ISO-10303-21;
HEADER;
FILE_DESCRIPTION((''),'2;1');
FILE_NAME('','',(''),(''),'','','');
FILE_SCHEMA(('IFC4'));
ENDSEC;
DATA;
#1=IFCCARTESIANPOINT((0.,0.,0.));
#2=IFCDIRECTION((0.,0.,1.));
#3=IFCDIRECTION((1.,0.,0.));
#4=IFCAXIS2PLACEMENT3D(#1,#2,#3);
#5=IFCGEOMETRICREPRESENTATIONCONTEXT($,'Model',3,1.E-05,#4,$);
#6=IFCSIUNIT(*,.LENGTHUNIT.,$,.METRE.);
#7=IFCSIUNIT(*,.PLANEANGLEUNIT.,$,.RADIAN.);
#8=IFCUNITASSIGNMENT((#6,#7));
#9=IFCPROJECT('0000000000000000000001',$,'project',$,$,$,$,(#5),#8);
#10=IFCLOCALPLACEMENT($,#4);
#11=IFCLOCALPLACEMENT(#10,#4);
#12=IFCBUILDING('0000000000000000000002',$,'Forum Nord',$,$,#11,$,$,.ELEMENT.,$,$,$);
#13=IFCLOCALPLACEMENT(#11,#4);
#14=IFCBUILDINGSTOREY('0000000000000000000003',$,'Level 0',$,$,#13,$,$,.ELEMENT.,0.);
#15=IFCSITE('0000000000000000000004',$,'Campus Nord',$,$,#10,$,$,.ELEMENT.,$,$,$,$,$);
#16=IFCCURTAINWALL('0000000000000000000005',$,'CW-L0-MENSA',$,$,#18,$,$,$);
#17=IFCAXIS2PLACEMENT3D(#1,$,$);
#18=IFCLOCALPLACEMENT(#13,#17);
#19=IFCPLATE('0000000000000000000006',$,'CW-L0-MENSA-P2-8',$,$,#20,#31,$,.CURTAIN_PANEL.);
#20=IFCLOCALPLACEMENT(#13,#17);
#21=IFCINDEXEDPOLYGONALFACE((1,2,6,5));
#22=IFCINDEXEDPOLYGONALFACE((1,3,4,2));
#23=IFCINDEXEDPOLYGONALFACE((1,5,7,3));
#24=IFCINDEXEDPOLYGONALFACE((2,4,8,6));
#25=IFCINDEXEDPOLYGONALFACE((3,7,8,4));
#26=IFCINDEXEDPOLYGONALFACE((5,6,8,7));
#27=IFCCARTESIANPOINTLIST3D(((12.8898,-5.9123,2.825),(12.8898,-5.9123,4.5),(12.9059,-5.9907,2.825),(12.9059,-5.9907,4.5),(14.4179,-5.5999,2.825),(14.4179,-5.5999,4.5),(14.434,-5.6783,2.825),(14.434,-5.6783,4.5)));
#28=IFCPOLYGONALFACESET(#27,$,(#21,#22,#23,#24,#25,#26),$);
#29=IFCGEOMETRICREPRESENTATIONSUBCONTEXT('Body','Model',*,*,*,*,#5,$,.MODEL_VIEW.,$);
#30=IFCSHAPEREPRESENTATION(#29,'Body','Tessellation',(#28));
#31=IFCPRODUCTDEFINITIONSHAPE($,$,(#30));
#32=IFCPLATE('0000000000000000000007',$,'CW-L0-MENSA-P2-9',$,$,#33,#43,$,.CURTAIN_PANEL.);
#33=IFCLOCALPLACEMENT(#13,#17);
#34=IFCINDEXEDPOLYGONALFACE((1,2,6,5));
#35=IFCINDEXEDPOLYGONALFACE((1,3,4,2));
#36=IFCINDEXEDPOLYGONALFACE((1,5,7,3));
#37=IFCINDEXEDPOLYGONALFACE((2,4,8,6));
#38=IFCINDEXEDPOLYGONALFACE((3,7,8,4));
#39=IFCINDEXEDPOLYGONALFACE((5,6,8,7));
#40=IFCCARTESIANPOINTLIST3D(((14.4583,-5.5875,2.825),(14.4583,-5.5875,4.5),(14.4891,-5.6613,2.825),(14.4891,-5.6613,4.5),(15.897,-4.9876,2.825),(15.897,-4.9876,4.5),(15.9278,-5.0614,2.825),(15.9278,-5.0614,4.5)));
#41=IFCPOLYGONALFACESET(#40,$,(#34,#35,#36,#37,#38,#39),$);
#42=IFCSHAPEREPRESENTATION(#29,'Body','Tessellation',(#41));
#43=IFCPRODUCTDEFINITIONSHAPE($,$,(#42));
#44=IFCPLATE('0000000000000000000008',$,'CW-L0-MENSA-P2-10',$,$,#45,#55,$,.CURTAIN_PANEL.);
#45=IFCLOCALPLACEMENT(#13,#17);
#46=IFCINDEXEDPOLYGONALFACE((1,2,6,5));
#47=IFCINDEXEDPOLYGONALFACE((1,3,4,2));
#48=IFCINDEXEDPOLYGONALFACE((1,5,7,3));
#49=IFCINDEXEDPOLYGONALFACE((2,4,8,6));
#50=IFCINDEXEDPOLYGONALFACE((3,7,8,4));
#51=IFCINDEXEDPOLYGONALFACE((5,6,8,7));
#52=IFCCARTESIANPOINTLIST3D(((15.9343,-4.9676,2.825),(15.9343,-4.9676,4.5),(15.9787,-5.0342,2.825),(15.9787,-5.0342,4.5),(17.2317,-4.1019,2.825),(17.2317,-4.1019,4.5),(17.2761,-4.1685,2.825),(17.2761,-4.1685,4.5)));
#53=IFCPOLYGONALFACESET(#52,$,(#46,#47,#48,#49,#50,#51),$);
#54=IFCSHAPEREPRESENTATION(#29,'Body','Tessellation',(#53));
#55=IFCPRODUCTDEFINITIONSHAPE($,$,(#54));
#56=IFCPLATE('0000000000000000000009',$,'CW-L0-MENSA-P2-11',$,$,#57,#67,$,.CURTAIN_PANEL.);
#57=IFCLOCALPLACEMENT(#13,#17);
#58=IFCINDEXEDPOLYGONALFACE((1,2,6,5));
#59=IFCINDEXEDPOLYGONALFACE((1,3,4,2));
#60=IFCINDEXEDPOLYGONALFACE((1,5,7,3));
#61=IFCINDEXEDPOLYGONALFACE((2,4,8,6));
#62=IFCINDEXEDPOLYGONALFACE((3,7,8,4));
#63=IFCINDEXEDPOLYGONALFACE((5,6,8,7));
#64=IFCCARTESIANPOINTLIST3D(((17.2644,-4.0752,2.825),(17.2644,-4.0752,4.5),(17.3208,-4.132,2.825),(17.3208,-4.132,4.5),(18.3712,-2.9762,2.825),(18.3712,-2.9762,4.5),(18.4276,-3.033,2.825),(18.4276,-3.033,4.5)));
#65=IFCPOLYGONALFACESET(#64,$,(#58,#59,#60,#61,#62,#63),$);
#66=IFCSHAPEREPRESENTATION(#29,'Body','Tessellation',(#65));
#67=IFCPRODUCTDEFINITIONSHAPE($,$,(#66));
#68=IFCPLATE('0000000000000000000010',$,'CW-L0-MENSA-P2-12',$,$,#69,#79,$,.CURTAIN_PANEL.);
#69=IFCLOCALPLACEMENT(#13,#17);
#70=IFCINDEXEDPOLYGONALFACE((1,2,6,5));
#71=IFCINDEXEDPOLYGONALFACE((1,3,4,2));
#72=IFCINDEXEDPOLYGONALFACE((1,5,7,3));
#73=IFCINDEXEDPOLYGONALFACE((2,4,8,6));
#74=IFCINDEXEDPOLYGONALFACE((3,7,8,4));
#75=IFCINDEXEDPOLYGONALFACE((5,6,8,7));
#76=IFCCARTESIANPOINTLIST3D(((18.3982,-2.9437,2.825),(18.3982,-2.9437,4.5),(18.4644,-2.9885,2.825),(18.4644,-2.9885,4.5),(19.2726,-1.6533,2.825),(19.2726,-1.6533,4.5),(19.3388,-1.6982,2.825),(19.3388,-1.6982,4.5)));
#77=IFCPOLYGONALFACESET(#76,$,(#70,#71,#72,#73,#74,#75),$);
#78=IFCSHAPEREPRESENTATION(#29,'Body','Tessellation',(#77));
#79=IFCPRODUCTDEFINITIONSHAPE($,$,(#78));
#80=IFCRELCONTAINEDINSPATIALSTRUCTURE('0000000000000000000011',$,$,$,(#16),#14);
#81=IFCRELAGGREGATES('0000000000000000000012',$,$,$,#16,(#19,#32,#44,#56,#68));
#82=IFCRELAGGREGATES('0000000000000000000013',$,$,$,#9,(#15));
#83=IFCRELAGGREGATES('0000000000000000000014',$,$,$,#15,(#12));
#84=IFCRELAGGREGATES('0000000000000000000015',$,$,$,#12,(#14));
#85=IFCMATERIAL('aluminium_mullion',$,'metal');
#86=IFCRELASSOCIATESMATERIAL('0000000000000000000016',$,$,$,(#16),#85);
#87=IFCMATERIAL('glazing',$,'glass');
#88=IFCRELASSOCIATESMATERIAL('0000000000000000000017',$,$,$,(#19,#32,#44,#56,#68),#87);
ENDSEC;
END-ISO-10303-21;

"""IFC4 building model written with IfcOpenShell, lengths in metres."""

from ifc_helpers import new_model, si_unit, frame, frame_2d, origin_with_axes, place, context, subcontext, project, spatial, rectangle, extrude, material, element, aggregate, save


model = new_model("IFC4")

# Units and contexts
model_context = context("Model", 3, precision=1e-05, world=origin_with_axes())
body_context = subcontext(model_context, "Body", "Model", "MODEL_VIEW")
ifc_project = project(units=[si_unit("LENGTHUNIT", "METRE"), si_unit("PLANEANGLEUNIT", "RADIAN")], contexts=[model_context])

# Site, building, storey
site_placement = place(None, origin_with_axes())
site = spatial("IfcSite", under=ifc_project, at=site_placement, Name="Campus Nord", CompositionType="ELEMENT")
building_placement = place(site_placement, origin_with_axes())
building = spatial("IfcBuilding", under=site, at=building_placement, Name="Forum Nord", CompositionType="ELEMENT")
storey_placement = place(building_placement, origin_with_axes())
storey = spatial("IfcBuildingStorey", under=building, at=storey_placement, Name="Level 0", CompositionType="ELEMENT", Elevation=0.0)

# Curtain wall, plates
ifc_material_1 = material(Name="aluminium_mullion", Category="metal")
curtain_wall_placement = place(storey_placement, origin_with_axes())
curtain_wall = element("IfcCurtainWall", 1, at=curtain_wall_placement, inside=storey, material=ifc_material_1, Name="CW-L0-MENSA")
ifc_material_2 = material(Name="glazing", Category="glass")
plate_1_placement = place(storey_placement, frame((12.8979, -5.9515, 2.825), z_axis=(0.0, 0.0, 1.0), x_axis=(0.97973, 0.2003, 0.0)))
plate_1 = element("IfcPlate", 2, at=plate_1_placement, material=ifc_material_2, Name="CW-L0-MENSA-P2-8", PredefinedType="CURTAIN_PANEL", context=body_context, shape_type="SweptSolid", body=[
    extrude(rectangle(XDim=1.5597, YDim=0.08, at=frame_2d((0.7799, 0.0), x_axis=(1.0, 0.0))), origin_with_axes(), (0.0, 0.0, 1.0), 1.675),
])
plate_2_placement = place(storey_placement, frame((14.4737, -5.6244, 2.825), z_axis=(0.0, 0.0, 1.0), x_axis=(0.92298, 0.38484, 0.0)))
plate_2 = element("IfcPlate", 3, at=plate_2_placement, material=ifc_material_2, Name="CW-L0-MENSA-P2-9", PredefinedType="CURTAIN_PANEL", context=body_context, shape_type="SweptSolid", body=[
    extrude(rectangle(XDim=1.5587, YDim=0.08, at=frame_2d((0.7794, 0.0), x_axis=(1.0, 0.0))), origin_with_axes(), (0.0, 0.0, 1.0), 1.675),
])
plate_3_placement = place(storey_placement, frame((15.9565, -5.0009, 2.825), z_axis=(0.0, 0.0, 1.0), x_axis=(0.83182, 0.55504, 0.0)))
plate_3 = element("IfcPlate", 4, at=plate_3_placement, material=ifc_material_2, Name="CW-L0-MENSA-P2-10", PredefinedType="CURTAIN_PANEL", context=body_context, shape_type="SweptSolid", body=[
    extrude(rectangle(XDim=1.5597, YDim=0.08, at=frame_2d((0.7799, 0.0), x_axis=(1.0, 0.0))), origin_with_axes(), (0.0, 0.0, 1.0), 1.675),
])
plate_4_placement = place(storey_placement, frame((17.2926, -4.1036, 2.825), z_axis=(0.0, 0.0, 1.0), x_axis=(0.70961, 0.70459, 0.0)))
plate_4 = element("IfcPlate", 5, at=plate_4_placement, material=ifc_material_2, Name="CW-L0-MENSA-P2-11", PredefinedType="CURTAIN_PANEL", context=body_context, shape_type="SweptSolid", body=[
    extrude(rectangle(XDim=1.5597, YDim=0.08, at=frame_2d((0.7799, 0.0), x_axis=(1.0, 0.0))), origin_with_axes(), (0.0, 0.0, 1.0), 1.675),
])
plate_5_placement = place(storey_placement, frame((18.4313, -2.9661, 2.825), z_axis=(0.0, 0.0, 1.0), x_axis=(0.56098, 0.82783, 0.0)))
plate_5 = element("IfcPlate", 6, at=plate_5_placement, material=ifc_material_2, Name="CW-L0-MENSA-P2-12", PredefinedType="CURTAIN_PANEL", context=body_context, shape_type="SweptSolid", body=[
    extrude(rectangle(XDim=1.5587, YDim=0.08, at=frame_2d((0.7794, 0.0), x_axis=(1.0, 0.0))), origin_with_axes(), (0.0, 0.0, 1.0), 1.675),
])
aggregate(curtain_wall, [plate_1, plate_2, plate_3, plate_4, plate_5])

save(model, "model.ifc")
